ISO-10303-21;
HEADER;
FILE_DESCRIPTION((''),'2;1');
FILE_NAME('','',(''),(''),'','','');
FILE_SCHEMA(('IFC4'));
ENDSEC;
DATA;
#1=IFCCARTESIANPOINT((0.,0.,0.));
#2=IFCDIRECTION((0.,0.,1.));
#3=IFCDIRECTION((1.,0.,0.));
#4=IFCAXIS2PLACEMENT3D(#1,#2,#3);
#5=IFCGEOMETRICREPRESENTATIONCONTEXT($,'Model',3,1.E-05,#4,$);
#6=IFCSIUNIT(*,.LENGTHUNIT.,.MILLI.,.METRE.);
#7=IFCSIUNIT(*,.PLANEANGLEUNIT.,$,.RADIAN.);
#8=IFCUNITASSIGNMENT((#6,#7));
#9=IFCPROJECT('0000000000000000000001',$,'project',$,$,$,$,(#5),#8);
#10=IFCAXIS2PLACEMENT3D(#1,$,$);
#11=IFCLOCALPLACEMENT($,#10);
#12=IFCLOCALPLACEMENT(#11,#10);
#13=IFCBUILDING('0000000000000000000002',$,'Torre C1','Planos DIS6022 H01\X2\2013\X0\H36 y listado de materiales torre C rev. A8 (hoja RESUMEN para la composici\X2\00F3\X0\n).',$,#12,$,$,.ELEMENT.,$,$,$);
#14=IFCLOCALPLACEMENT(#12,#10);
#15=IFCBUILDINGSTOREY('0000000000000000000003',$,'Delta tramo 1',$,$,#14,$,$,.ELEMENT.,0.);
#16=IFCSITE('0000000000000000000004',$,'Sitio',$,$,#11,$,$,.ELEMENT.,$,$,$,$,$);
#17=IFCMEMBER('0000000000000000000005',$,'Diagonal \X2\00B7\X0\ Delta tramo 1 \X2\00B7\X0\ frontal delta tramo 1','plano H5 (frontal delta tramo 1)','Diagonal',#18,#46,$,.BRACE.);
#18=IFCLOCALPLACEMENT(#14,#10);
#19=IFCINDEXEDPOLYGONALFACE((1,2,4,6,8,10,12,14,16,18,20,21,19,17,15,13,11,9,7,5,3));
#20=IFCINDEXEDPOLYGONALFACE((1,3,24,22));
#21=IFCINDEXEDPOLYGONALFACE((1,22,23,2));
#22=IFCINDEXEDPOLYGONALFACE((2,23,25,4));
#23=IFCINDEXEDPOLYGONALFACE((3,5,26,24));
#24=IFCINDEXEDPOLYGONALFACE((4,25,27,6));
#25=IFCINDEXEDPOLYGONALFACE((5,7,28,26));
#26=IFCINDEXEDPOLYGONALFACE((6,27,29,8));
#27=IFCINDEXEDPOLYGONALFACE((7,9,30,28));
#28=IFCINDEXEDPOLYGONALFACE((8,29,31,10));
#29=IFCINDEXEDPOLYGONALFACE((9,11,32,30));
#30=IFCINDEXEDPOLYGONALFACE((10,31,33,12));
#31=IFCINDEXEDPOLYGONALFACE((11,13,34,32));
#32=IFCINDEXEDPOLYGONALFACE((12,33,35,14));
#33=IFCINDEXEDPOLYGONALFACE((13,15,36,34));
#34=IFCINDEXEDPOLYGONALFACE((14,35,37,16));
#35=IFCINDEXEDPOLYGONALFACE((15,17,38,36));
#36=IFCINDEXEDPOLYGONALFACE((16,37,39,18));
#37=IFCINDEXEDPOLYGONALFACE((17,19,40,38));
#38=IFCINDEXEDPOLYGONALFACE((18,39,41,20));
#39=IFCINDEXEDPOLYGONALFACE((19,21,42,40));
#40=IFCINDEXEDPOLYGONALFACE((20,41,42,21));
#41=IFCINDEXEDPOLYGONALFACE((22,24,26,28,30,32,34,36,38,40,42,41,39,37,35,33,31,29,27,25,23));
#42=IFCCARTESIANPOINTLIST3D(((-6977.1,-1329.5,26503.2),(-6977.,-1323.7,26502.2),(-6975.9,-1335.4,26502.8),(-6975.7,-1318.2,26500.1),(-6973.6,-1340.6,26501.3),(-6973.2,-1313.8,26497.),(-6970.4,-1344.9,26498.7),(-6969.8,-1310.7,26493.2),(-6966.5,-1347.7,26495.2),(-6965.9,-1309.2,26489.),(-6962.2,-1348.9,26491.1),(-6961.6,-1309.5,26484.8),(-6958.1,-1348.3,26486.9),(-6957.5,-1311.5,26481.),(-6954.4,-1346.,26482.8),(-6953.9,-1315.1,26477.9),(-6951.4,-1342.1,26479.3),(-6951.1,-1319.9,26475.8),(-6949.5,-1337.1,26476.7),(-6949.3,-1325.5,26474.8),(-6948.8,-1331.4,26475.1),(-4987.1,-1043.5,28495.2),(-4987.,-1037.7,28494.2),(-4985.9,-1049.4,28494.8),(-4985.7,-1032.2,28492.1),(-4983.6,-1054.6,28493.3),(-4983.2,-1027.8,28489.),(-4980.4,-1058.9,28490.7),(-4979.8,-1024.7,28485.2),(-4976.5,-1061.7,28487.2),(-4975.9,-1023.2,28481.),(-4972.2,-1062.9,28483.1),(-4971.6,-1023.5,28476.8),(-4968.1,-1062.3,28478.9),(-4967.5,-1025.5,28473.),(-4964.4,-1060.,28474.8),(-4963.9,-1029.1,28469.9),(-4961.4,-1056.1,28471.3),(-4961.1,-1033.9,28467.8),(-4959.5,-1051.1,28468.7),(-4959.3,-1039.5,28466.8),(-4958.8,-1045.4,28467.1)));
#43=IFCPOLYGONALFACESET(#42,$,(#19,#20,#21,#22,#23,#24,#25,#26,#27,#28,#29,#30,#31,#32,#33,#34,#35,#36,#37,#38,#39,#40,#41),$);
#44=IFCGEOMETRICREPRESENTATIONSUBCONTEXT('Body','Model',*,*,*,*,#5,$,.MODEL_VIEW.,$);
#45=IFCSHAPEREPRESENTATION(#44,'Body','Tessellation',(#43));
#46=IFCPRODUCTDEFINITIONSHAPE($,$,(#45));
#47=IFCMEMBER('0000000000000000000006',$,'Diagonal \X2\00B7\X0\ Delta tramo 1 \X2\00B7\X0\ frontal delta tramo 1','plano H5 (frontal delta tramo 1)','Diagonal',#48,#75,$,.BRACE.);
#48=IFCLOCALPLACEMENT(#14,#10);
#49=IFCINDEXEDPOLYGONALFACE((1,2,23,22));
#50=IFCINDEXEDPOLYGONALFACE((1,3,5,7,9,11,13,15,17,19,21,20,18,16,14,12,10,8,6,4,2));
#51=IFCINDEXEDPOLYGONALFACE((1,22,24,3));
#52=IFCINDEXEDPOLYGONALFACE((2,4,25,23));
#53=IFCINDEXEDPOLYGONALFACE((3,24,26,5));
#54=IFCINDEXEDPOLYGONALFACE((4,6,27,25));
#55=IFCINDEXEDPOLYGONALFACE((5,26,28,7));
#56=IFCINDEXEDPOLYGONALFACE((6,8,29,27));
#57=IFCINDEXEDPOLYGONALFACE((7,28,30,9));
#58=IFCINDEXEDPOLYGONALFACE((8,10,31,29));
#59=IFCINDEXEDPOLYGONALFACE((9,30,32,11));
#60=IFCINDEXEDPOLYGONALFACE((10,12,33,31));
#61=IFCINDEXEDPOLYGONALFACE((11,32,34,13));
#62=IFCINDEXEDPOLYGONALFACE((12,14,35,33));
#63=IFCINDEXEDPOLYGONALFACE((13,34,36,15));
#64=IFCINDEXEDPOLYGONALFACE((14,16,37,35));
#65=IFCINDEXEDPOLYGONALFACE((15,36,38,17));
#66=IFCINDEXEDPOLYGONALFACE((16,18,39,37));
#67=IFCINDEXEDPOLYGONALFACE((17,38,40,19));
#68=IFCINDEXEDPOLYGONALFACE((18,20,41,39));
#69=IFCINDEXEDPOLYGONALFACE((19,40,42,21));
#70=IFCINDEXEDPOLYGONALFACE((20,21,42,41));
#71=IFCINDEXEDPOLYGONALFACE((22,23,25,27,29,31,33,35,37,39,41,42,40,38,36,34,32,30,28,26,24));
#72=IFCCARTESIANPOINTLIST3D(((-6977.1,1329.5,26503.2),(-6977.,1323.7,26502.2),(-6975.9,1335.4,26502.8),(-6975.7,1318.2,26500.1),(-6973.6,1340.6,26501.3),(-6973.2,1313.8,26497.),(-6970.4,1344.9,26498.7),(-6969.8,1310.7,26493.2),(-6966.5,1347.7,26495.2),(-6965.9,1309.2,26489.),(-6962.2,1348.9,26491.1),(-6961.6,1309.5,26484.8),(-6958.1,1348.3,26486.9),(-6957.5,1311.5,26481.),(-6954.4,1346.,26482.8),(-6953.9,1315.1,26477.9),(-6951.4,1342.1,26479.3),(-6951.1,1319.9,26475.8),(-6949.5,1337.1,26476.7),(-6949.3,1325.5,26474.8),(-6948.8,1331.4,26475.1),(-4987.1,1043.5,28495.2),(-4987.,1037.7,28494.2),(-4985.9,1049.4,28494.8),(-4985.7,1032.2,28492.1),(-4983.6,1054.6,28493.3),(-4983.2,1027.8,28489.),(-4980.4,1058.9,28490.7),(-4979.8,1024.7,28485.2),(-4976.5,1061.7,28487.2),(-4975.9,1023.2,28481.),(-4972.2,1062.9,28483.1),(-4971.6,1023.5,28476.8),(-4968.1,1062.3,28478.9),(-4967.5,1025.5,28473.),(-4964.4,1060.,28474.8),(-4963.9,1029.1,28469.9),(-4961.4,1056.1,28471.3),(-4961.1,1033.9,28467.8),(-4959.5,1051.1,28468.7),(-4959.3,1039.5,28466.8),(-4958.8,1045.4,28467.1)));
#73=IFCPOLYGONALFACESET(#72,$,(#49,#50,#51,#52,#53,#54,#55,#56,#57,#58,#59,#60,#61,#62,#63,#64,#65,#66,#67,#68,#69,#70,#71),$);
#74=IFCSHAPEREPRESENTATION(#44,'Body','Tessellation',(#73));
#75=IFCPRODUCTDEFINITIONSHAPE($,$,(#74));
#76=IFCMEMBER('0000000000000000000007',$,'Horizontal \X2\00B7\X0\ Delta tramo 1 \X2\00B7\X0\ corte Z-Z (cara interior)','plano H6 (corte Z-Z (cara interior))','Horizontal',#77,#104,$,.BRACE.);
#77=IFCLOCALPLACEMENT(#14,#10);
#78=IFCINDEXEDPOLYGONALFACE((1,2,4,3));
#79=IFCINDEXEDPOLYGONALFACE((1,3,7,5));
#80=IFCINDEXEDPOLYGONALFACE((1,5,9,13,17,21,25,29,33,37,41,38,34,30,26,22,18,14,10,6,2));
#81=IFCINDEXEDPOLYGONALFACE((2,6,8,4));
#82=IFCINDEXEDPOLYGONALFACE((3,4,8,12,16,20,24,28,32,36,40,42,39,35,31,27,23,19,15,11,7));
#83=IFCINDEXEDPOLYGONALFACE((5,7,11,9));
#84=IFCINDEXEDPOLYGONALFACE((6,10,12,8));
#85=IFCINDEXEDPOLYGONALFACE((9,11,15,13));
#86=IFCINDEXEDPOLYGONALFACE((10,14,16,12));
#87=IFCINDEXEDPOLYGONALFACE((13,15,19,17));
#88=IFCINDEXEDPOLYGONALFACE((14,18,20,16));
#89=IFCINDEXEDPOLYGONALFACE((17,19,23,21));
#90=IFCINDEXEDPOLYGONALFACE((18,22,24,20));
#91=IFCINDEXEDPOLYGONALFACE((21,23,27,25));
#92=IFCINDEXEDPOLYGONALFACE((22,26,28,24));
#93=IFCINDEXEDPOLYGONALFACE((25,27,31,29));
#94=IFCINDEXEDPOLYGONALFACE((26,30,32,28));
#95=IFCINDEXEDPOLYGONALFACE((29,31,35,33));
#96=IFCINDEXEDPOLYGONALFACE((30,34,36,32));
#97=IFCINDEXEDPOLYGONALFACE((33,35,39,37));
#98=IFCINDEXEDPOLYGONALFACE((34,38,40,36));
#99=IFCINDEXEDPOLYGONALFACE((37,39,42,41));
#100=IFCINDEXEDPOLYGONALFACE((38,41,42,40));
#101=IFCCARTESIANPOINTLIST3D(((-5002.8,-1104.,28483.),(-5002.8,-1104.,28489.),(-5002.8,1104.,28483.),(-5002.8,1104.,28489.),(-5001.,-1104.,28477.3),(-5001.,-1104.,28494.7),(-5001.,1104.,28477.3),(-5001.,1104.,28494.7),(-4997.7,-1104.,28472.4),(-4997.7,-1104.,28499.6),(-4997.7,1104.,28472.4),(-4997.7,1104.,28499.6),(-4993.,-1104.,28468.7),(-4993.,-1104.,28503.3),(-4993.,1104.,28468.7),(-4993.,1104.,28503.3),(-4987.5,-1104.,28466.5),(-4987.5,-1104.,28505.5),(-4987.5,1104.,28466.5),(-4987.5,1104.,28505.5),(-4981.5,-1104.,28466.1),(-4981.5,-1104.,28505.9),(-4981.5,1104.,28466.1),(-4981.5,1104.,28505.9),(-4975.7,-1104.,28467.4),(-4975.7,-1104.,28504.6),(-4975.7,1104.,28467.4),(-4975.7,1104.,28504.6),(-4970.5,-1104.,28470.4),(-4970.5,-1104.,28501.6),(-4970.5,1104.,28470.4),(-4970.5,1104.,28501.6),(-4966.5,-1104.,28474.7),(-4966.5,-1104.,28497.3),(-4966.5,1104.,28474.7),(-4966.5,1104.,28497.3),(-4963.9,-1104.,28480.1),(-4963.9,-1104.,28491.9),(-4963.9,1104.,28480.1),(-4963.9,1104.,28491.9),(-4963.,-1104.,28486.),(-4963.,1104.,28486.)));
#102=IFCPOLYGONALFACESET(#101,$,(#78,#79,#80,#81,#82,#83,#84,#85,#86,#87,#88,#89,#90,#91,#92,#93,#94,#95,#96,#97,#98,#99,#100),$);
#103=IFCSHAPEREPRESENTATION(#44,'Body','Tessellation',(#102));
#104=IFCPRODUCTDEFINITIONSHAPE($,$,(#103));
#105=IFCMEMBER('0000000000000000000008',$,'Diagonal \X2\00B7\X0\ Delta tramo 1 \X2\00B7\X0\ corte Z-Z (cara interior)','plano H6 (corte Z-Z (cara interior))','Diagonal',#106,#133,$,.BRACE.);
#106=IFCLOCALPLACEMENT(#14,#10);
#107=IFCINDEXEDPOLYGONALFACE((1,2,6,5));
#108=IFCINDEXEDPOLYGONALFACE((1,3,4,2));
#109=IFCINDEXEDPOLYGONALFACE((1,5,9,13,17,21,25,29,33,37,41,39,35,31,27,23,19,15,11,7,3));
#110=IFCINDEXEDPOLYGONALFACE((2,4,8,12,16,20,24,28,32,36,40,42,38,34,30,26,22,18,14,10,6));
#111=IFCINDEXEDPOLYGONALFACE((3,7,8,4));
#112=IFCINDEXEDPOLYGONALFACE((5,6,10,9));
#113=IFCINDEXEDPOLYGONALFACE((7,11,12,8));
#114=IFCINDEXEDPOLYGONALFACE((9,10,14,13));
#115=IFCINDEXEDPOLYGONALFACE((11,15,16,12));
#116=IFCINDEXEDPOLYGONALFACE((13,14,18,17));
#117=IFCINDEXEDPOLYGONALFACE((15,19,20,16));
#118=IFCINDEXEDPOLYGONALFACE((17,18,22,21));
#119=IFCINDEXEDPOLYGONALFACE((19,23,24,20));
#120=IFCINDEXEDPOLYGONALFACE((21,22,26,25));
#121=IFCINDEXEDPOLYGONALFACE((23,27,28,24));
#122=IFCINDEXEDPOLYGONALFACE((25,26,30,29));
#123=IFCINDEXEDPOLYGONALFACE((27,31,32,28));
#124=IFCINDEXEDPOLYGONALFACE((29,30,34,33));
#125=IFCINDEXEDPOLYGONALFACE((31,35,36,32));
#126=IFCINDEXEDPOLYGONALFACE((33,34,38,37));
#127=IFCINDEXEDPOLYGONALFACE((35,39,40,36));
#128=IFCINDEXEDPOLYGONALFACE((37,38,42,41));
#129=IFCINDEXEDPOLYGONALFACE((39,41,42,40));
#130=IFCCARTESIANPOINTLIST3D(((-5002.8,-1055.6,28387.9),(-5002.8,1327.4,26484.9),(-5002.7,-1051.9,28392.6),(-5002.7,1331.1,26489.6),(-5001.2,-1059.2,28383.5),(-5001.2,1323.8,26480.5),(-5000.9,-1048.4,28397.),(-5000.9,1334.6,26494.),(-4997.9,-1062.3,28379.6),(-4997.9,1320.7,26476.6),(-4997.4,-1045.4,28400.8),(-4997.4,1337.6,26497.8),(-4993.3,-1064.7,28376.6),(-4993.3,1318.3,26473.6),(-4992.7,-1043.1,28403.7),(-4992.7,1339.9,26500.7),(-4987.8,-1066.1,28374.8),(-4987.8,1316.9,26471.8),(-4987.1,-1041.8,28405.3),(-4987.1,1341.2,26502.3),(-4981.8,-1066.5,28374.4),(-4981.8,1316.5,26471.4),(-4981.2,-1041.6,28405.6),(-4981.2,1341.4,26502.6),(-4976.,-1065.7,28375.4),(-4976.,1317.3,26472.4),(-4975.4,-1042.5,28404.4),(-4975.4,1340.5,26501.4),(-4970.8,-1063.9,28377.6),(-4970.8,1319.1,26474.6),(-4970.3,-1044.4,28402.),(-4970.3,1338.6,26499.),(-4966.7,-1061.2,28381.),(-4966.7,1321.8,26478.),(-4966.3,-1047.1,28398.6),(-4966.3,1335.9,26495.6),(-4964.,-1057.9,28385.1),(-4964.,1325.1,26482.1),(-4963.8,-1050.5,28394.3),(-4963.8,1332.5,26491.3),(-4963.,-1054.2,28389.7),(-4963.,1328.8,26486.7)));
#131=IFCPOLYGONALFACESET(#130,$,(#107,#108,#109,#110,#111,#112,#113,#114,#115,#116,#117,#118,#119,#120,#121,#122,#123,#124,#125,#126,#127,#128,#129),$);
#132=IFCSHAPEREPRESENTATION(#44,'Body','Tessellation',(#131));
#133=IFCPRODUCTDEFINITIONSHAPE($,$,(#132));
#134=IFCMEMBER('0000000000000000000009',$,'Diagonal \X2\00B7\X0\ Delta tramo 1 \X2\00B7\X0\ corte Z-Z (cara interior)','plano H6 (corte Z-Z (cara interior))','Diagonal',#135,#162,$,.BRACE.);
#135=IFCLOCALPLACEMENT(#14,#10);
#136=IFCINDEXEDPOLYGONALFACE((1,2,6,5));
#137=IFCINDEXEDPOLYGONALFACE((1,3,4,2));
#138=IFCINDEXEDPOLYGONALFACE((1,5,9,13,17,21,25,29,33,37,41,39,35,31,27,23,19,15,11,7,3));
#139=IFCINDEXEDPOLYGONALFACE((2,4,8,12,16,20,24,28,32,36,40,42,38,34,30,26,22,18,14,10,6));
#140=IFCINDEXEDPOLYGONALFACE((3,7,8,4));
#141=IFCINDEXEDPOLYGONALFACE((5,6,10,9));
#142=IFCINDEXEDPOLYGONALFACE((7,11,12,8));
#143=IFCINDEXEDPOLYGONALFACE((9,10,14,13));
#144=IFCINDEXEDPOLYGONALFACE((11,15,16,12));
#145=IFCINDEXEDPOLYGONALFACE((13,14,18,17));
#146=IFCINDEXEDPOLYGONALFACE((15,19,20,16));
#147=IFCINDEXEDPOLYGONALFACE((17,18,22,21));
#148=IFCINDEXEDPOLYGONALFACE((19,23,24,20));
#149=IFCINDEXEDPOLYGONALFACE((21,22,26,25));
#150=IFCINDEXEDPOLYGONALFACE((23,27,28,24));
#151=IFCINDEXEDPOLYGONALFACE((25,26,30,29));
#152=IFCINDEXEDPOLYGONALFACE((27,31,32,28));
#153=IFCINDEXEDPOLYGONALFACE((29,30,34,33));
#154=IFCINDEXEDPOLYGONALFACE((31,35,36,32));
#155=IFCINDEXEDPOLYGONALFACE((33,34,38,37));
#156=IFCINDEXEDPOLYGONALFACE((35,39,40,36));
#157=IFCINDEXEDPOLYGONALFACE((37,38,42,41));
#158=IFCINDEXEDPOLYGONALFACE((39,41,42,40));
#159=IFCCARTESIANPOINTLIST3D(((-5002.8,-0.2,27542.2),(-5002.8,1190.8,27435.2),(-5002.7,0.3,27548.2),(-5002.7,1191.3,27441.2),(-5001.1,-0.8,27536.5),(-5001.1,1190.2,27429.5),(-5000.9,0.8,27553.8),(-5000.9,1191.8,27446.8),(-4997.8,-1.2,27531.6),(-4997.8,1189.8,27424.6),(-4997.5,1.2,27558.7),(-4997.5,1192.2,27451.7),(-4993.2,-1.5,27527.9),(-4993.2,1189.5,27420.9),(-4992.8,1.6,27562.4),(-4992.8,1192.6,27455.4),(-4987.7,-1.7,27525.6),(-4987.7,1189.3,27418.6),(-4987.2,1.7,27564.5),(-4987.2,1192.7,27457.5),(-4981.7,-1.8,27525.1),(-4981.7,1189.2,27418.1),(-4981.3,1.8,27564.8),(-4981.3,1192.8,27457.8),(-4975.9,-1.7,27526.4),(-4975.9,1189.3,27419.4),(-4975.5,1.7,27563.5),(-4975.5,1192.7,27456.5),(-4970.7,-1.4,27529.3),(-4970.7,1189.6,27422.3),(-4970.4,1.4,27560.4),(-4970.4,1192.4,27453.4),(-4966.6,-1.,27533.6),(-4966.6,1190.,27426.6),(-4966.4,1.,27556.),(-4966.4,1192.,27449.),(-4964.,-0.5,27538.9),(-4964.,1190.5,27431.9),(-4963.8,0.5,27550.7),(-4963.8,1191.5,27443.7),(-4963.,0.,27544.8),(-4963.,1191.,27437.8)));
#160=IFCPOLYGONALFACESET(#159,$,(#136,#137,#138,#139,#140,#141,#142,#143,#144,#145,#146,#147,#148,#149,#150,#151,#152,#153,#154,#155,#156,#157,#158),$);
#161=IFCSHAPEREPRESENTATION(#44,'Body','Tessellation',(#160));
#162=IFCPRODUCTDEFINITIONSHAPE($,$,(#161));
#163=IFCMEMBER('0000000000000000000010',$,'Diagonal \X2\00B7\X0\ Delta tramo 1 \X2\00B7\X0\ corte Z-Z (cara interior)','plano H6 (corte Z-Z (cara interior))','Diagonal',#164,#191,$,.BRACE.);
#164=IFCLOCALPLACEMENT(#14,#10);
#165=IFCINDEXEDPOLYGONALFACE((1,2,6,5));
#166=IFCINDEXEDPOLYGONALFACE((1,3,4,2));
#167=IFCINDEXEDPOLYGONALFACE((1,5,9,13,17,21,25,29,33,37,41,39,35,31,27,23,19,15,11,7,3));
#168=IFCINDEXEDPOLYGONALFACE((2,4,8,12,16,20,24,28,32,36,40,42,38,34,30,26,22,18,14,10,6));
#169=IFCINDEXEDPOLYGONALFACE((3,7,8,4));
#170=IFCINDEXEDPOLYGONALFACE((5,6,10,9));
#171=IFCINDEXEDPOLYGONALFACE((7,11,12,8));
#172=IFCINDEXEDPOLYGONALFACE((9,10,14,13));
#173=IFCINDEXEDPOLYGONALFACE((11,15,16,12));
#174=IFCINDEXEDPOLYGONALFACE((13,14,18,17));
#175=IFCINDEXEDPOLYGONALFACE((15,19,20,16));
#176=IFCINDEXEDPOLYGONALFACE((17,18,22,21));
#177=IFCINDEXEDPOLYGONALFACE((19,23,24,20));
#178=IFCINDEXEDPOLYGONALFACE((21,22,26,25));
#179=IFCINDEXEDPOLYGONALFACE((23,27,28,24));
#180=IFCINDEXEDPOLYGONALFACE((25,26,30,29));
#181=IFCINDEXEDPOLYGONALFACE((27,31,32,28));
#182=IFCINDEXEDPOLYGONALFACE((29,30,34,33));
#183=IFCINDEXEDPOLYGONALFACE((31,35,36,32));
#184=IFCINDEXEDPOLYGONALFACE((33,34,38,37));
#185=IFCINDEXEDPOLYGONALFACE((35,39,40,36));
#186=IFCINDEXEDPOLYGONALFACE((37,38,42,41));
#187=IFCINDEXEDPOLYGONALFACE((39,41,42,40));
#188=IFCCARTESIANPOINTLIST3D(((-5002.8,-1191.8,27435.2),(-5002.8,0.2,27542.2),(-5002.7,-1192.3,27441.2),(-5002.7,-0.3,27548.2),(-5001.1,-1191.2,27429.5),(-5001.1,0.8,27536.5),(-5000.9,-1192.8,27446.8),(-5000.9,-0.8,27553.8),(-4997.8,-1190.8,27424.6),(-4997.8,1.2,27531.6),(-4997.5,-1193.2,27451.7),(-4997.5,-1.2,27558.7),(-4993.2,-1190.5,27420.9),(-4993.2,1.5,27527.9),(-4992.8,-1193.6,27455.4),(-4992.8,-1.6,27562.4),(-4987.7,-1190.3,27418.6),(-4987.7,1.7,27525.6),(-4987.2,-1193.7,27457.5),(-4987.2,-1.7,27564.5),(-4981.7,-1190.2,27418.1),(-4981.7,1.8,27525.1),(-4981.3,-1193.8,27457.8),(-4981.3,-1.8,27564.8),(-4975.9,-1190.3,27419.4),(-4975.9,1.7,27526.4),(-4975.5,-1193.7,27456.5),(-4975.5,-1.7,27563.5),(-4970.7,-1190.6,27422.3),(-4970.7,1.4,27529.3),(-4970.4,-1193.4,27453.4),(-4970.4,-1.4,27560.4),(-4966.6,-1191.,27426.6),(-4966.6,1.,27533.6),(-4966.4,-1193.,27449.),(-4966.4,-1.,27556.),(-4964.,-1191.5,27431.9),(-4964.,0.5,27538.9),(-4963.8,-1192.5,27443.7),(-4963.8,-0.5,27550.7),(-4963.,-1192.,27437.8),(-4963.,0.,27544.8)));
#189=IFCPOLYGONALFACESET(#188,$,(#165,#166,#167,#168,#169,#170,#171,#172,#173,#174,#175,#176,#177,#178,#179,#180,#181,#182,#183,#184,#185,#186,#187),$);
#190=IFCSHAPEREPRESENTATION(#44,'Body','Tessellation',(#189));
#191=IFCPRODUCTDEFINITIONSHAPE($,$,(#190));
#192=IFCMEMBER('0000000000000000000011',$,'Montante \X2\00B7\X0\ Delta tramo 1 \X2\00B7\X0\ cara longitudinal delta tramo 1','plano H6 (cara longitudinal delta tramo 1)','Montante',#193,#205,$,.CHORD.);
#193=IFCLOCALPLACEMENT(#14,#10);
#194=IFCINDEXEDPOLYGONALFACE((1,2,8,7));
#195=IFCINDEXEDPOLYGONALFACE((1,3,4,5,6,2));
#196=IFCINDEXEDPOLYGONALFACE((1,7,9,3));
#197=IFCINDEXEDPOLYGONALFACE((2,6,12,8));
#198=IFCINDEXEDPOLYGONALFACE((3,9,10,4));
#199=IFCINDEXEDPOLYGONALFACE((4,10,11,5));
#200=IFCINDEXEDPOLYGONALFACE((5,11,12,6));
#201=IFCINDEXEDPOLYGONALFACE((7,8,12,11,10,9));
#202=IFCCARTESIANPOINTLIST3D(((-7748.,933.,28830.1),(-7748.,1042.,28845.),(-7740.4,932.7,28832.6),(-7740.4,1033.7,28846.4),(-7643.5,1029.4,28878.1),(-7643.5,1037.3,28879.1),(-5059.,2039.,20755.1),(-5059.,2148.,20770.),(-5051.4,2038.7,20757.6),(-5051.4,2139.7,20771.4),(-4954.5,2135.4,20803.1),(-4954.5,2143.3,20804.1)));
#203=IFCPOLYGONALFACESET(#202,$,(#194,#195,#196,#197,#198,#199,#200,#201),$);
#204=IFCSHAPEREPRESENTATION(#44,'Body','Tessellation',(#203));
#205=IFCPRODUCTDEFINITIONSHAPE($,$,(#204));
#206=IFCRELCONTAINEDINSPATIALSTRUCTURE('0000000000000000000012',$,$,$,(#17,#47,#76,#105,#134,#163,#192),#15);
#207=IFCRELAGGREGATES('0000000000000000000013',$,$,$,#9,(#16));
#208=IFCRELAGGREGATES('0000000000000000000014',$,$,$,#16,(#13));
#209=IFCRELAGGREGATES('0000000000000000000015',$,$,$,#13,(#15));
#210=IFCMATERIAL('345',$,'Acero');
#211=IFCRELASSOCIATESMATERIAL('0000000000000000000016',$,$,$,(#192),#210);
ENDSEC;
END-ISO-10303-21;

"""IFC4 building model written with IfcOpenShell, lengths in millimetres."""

from ifc_helpers import new_model, si_unit, frame, frame_2d, origin, origin_with_axes, place, context, subcontext, project, spatial, circle, l_section, extrude, material, element, save


model = new_model("IFC4")

# Units and contexts
model_context = context("Model", 3, precision=1e-05, world=origin_with_axes())
body_context = subcontext(model_context, "Body", "Model", "MODEL_VIEW")
ifc_project = project(units=[si_unit("LENGTHUNIT", "METRE", prefix="MILLI"), si_unit("PLANEANGLEUNIT", "RADIAN")], contexts=[model_context])

# Site, building, storey
site_placement = place(None, origin())
site = spatial("IfcSite", under=ifc_project, at=site_placement, Name="Sitio", CompositionType="ELEMENT")
building_placement = place(site_placement, origin())
building = spatial("IfcBuilding", under=site, at=building_placement, Name="Torre C1", Description="Planos DIS6022 H01–H36 y listado de materiales torre C rev. A8 (hoja RESUMEN para la composición).", CompositionType="ELEMENT")
storey_placement = place(building_placement, origin())
storey = spatial("IfcBuildingStorey", under=building, at=storey_placement, Name="Delta tramo 1", CompositionType="ELEMENT", Elevation=0.0)

# Members
ifc_material = material(Name="345", Category="Acero")
for number, where, z_axis, x_axis, name in (
    (1, (-4973.0, -1043.0, 28481.0), (-0.703134, -0.101053, -0.70384), (0.683901, 0.174833, -0.708316), "Diagonal · Delta tramo 1 · frontal delta tramo 1"),
    (2, (-4973.0, 1043.0, 28481.0), (-0.703134, 0.101053, -0.70384), (0.683901, -0.174833, -0.708316), "Diagonal · Delta tramo 1 · frontal delta tramo 1"),
):
    element("IfcMember", number, at=place(storey_placement, frame(where, z_axis=z_axis, x_axis=x_axis)), inside=storey, Name=name, Description="plano H5 (frontal delta tramo 1)", ObjectType="Diagonal", PredefinedType="BRACE", context=body_context, shape_type="SweptSolid", body=[
        extrude(circle(Radius=20.0), None, (0.0, 0.0, 1.0), 2830.2),
    ])
member_1_placement = place(storey_placement, frame((-4983.0, -1104.0, 28486.0), z_axis=(0.0, 1.0, 0.0), x_axis=(1.0, 0.0, 0.0)))
element("IfcMember", 3, at=member_1_placement, inside=storey, Name="Horizontal · Delta tramo 1 · corte Z-Z (cara interior)", Description="plano H6 (corte Z-Z (cara interior))", ObjectType="Horizontal", PredefinedType="BRACE", context=body_context, shape_type="SweptSolid", body=[
    extrude(circle(Radius=20.0), None, (0.0, 0.0, 1.0), 2208.0),
])
member_2_placement = place(storey_placement, frame((-4983.0, -1054.0, 28390.0), z_axis=(0.0, 0.781412, -0.624015), x_axis=(0.999852, -0.010743, -0.013453)))
element("IfcMember", 4, at=member_2_placement, inside=storey, Name="Diagonal · Delta tramo 1 · corte Z-Z (cara interior)", Description="plano H6 (corte Z-Z (cara interior))", ObjectType="Diagonal", PredefinedType="BRACE", context=body_context, shape_type="SweptSolid", body=[
    extrude(circle(Radius=20.0), None, (0.0, 0.0, 1.0), 3049.6),
])
member_3_placement = place(storey_placement, frame((-4983.0, 1191.0, 27438.0), z_axis=(0.0, -0.995989, 0.08948), x_axis=(0.999943, -0.000957, -0.01065)))
element("IfcMember", 5, at=member_3_placement, inside=storey, Name="Diagonal · Delta tramo 1 · corte Z-Z (cara interior)", Description="plano H6 (corte Z-Z (cara interior))", ObjectType="Diagonal", PredefinedType="BRACE", context=body_context, shape_type="SweptSolid", body=[
    extrude(circle(Radius=20.0), None, (0.0, 0.0, 1.0), 1195.8),
])
member_4_placement = place(storey_placement, frame((-4983.0, -1192.0, 27438.0), z_axis=(0.0, 0.995995, 0.089406), x_axis=(0.999943, 0.000956, -0.01065)))
element("IfcMember", 6, at=member_4_placement, inside=storey, Name="Diagonal · Delta tramo 1 · corte Z-Z (cara interior)", Description="plano H6 (corte Z-Z (cara interior))", ObjectType="Diagonal", PredefinedType="BRACE", context=body_context, shape_type="SweptSolid", body=[
    extrude(circle(Radius=20.0), None, (0.0, 0.0, 1.0), 1196.8),
])
member_5_placement = place(storey_placement, frame((-7748.0, 1042.0, 28845.0), z_axis=(0.313311, 0.128867, -0.940866), x_axis=(0.94965, -0.042516, 0.310413)))
element("IfcMember", 7, at=member_5_placement, inside=storey, material=ifc_material, Name="Montante · Delta tramo 1 · cara longitudinal delta tramo 1", Description="plano H6 (cara longitudinal delta tramo 1)", ObjectType="Montante", PredefinedType="CHORD", context=body_context, shape_type="SweptSolid", body=[
    extrude(l_section(Depth=110.0, Width=110.0, Thickness=8.0, at=frame_2d((55.0, 55.0))), None, (0.0, 0.0, 1.0), 8582.5),
])

save(model, "model.ifc")
